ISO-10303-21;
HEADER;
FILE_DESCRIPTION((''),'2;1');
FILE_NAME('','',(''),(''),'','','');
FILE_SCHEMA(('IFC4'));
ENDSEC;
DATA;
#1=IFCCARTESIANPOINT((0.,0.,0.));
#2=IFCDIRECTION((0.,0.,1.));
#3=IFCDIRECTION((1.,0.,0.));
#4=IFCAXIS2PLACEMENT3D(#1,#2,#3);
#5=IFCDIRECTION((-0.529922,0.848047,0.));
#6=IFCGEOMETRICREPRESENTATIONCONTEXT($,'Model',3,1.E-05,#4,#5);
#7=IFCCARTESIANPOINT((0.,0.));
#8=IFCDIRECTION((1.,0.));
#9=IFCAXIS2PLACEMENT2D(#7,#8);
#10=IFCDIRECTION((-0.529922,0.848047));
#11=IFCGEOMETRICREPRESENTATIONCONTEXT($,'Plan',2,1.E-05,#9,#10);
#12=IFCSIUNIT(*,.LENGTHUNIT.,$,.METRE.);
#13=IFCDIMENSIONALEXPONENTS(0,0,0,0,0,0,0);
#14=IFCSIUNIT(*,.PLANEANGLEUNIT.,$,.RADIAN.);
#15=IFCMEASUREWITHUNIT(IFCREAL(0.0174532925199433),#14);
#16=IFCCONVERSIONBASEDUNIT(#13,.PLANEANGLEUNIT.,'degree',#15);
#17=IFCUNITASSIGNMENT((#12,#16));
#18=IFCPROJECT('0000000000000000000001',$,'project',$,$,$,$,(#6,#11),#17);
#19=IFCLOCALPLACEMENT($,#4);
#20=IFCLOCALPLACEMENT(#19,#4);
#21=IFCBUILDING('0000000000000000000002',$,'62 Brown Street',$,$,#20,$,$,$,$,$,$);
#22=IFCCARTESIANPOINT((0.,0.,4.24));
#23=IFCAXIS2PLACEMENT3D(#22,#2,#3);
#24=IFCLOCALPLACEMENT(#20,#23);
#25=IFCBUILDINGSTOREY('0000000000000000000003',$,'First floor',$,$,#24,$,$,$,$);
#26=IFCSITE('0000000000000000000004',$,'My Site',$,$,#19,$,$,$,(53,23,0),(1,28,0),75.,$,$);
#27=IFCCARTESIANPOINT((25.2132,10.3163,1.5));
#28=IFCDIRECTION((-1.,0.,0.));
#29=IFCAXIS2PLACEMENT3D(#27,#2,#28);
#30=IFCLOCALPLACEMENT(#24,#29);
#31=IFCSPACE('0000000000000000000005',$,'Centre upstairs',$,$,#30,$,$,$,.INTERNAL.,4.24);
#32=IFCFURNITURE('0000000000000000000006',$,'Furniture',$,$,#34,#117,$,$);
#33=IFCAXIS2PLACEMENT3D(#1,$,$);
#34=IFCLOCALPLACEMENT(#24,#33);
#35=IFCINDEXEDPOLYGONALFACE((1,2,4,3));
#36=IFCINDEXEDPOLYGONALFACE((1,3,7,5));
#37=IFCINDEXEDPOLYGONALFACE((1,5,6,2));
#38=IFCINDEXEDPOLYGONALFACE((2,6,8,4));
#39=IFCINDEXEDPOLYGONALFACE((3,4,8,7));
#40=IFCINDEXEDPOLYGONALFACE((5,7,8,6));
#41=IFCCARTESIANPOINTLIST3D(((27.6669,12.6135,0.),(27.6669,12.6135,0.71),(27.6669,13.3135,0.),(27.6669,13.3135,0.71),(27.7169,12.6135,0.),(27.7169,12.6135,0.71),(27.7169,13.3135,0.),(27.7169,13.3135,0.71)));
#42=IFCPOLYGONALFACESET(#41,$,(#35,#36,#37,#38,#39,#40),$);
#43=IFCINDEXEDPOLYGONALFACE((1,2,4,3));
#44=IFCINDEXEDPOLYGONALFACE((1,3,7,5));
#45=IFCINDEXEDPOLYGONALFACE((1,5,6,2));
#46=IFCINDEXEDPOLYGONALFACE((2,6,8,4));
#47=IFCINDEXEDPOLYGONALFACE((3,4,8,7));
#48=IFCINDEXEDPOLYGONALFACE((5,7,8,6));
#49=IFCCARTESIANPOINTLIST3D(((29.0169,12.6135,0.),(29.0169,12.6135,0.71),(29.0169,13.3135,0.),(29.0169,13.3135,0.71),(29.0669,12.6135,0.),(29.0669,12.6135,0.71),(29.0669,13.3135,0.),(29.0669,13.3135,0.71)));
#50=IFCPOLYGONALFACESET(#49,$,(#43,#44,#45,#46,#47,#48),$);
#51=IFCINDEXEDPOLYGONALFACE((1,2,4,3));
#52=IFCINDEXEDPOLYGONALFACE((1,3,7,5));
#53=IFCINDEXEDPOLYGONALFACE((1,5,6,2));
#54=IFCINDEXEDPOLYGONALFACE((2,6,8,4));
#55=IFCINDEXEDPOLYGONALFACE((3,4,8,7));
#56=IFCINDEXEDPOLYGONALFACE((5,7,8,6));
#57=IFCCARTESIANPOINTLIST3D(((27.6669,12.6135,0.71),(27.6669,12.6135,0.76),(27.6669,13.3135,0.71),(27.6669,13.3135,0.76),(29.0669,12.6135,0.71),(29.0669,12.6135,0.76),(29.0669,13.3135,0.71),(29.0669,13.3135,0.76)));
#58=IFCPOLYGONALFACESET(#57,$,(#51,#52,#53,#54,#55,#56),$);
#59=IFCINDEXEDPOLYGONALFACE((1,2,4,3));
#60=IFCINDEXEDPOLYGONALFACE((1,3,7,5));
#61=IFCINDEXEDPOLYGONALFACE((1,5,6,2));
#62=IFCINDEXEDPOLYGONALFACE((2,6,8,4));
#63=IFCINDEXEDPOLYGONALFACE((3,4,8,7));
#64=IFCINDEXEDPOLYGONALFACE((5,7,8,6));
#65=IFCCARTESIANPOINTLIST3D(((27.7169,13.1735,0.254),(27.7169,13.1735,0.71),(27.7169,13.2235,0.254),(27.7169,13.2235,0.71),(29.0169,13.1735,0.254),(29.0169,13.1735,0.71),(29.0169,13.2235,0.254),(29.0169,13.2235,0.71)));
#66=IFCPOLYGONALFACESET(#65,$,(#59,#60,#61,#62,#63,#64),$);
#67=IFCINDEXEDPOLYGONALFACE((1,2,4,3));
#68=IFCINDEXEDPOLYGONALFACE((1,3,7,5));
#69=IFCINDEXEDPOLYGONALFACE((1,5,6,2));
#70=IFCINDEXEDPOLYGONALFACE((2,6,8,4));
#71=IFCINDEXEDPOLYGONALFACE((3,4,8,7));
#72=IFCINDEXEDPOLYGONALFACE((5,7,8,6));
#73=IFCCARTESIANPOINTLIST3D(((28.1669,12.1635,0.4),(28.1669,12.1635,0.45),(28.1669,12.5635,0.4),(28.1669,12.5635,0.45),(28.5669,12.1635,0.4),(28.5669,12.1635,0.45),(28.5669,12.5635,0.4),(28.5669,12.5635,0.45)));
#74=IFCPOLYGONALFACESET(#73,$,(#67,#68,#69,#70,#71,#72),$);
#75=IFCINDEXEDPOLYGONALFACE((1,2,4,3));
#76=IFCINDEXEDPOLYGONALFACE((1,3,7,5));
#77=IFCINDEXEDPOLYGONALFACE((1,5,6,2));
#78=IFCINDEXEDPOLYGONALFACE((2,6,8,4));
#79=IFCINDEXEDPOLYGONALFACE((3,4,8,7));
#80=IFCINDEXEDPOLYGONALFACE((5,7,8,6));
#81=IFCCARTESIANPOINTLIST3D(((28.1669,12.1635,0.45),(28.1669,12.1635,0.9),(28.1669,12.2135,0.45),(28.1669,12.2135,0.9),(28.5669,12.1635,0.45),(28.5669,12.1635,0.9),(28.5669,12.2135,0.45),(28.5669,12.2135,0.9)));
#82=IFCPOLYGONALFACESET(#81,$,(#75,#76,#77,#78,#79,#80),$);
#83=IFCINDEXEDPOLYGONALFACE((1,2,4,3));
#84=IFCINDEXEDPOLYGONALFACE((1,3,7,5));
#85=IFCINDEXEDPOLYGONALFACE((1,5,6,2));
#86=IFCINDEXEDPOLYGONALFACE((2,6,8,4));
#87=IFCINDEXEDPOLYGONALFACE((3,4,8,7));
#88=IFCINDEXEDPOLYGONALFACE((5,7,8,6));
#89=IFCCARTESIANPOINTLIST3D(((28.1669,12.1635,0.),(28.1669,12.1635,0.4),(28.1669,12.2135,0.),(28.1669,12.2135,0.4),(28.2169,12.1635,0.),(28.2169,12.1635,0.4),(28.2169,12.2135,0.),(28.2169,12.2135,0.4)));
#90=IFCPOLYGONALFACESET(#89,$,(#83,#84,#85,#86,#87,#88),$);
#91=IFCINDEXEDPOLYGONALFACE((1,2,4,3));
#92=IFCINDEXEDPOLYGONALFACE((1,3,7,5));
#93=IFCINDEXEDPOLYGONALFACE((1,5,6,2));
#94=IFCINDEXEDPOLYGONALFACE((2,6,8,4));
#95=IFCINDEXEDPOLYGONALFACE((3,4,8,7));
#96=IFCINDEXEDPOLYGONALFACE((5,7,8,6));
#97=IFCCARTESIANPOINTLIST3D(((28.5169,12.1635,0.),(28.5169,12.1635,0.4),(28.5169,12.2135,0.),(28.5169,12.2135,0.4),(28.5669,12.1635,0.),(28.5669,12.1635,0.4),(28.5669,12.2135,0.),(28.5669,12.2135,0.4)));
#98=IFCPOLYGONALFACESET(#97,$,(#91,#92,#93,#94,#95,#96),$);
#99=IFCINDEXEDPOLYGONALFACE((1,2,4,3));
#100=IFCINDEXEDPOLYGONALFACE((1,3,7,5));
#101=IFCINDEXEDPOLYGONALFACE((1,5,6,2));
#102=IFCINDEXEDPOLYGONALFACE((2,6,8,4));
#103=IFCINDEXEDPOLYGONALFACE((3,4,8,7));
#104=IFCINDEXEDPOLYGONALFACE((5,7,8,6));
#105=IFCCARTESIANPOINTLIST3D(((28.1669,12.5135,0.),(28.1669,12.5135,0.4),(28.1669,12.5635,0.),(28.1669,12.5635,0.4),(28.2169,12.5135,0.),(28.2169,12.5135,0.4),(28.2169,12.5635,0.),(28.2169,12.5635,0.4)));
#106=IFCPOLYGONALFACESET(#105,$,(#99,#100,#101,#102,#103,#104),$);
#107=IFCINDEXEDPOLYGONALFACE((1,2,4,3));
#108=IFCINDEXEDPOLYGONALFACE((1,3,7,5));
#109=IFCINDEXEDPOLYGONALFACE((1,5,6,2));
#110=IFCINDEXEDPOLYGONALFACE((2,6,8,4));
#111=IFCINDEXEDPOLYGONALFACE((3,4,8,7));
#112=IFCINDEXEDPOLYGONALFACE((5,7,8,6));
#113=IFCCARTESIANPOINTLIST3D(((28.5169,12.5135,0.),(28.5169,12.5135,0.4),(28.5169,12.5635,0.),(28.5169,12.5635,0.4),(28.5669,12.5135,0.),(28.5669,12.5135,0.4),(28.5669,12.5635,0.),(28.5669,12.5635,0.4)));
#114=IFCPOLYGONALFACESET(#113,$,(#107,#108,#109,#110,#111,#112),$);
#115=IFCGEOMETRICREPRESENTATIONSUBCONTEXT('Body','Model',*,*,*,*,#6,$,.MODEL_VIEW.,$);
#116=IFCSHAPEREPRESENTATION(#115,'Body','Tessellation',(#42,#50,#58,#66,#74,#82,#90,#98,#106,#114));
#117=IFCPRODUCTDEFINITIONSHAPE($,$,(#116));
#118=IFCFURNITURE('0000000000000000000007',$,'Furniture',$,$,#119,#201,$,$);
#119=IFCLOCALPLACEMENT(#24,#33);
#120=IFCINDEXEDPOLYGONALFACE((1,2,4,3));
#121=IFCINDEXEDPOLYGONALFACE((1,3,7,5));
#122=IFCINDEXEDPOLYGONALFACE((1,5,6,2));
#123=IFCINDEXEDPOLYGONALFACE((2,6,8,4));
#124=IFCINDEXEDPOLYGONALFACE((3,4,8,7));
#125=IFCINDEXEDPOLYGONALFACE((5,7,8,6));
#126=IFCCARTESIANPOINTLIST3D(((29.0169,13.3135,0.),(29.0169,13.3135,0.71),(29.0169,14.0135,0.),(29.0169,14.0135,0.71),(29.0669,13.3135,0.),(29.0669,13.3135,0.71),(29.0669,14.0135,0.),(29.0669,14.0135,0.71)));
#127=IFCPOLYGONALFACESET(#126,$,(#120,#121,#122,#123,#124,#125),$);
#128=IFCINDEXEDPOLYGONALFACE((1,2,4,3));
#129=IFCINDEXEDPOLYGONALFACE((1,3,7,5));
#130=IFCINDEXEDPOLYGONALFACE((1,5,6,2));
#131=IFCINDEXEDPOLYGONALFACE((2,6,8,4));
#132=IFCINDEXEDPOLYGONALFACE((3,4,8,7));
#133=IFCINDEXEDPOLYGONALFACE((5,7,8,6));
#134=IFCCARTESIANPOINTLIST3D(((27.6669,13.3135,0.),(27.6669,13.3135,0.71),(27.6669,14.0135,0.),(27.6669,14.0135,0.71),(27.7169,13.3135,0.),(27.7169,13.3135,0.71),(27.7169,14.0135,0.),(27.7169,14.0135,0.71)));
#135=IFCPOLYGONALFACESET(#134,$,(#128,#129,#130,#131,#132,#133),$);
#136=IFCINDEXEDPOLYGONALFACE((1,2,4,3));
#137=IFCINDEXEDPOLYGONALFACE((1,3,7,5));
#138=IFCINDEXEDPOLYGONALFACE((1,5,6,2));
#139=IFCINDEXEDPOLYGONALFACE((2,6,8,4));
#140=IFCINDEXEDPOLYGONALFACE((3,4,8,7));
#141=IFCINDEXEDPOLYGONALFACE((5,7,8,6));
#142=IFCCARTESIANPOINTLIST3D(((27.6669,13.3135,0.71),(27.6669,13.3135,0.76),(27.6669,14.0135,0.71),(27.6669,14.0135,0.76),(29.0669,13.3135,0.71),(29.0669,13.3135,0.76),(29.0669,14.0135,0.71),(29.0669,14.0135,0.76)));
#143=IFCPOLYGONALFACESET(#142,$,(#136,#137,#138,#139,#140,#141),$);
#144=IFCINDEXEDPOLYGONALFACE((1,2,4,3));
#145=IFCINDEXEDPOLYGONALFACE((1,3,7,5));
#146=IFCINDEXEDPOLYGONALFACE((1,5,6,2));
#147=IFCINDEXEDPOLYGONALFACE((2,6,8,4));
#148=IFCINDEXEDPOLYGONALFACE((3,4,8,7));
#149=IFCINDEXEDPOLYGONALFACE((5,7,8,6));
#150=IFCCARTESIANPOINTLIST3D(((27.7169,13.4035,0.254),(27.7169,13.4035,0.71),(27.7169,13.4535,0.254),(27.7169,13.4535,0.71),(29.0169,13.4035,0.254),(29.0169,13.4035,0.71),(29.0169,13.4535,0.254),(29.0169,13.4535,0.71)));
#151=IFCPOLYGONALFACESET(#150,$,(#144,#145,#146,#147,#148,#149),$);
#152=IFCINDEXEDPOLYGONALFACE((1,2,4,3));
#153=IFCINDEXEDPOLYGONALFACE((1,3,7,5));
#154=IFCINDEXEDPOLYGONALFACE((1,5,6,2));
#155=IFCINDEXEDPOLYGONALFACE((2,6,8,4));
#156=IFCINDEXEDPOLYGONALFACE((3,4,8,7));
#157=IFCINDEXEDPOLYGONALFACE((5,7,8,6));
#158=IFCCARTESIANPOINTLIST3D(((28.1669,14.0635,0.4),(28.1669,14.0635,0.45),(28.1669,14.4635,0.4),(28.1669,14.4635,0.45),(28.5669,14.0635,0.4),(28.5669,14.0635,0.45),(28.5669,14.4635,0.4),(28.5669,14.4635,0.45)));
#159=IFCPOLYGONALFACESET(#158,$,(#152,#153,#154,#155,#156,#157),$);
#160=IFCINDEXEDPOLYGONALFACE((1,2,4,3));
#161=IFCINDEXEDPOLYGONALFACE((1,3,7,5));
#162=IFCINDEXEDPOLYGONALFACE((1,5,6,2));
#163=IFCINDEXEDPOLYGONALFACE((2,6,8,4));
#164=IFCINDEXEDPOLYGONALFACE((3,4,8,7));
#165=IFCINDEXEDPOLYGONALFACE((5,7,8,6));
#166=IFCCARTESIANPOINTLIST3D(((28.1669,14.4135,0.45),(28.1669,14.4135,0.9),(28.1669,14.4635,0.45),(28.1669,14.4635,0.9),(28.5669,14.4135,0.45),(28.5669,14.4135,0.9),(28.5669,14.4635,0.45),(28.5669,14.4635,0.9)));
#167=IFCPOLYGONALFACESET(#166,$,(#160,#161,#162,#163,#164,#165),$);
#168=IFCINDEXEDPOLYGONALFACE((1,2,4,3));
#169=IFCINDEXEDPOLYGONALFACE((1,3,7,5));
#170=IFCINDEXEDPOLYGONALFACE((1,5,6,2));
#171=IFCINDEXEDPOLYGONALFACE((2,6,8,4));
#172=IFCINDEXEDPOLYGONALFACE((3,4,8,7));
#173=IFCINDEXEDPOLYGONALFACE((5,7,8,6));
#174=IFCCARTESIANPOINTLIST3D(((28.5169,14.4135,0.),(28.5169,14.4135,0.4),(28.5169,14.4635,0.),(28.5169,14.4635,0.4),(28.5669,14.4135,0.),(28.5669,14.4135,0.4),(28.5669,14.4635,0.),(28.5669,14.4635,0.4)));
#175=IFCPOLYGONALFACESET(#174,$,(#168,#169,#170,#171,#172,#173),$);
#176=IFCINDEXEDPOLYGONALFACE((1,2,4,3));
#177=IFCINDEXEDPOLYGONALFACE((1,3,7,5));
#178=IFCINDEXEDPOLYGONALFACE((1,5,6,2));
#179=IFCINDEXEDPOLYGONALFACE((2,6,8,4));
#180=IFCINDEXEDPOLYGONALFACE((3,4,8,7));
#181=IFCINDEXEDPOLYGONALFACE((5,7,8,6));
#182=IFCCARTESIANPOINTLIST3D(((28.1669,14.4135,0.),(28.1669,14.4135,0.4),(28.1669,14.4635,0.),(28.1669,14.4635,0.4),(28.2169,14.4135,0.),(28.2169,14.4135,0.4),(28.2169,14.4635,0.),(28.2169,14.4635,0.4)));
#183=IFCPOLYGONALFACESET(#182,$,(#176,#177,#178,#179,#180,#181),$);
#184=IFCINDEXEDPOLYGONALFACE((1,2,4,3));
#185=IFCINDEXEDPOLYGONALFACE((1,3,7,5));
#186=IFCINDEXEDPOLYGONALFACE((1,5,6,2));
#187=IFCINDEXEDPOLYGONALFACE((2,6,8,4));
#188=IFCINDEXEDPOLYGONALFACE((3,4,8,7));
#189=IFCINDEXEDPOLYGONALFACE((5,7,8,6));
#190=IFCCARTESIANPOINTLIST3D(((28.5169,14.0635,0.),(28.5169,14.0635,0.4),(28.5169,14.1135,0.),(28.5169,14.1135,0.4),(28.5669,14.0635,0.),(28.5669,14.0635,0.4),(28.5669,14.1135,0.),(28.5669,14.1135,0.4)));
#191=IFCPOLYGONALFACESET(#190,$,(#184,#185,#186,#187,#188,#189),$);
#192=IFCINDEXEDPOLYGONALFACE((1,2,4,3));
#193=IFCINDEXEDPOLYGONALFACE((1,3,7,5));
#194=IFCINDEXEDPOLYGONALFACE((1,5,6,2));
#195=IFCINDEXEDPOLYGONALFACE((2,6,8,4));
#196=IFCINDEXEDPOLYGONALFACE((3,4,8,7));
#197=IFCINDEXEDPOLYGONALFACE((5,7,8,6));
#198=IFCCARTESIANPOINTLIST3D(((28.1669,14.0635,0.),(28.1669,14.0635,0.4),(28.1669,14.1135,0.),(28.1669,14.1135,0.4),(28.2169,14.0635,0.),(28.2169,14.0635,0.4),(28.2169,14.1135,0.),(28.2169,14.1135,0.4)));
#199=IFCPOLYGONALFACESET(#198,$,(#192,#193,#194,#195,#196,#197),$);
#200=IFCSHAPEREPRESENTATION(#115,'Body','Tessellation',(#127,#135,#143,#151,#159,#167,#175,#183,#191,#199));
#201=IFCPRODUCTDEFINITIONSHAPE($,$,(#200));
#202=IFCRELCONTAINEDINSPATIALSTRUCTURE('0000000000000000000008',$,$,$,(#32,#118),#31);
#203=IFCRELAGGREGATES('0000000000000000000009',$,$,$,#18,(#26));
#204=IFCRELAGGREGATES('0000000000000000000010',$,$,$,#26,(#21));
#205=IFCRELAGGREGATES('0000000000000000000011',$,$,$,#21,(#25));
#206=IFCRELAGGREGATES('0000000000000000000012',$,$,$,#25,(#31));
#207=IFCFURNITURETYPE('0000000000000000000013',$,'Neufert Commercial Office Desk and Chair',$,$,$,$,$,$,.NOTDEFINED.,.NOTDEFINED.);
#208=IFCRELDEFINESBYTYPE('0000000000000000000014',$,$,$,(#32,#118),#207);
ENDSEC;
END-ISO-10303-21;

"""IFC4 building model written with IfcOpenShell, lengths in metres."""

from ifc_helpers import new_model, entity, si_unit, converted_unit, direction, frame, origin_with_axes, origin_2d_with_axis, place, context, subcontext, project, spatial, line, indexed_curve, outline, extrude, shape, source, transform, mapped, type_object, type_shapes, element, save


model = new_model("IFC4")

# Units and contexts
model_context = context("Model", 3, precision=1e-05, world=origin_with_axes(), true_north=direction((-0.529922, 0.848047, 0.0)))
plan_context = context("Plan", 2, precision=1e-05, world=origin_2d_with_axis(), true_north=direction((-0.529922, 0.848047)))
body_context_1 = subcontext(model_context, "Body", "Model", "MODEL_VIEW")
body_context_2 = subcontext(plan_context, "Body", "Plan", "PLAN_VIEW")
ifc_project = project(units=[si_unit("LENGTHUNIT", "METRE"), converted_unit("PLANEANGLEUNIT", "degree", entity("IfcReal", 0.0174532925199433), si_unit("PLANEANGLEUNIT", "RADIAN"), dimensions=[0, 0, 0, 0, 0, 0, 0])], contexts=[model_context, plan_context])

# Site, building, storey, space
site_placement = place(None, origin_with_axes())
site = spatial("IfcSite", under=ifc_project, at=site_placement, Name="My Site", RefLatitude=(53, 23, 0), RefLongitude=(1, 28, 0), RefElevation=75.0)
building_placement = place(site_placement, origin_with_axes())
building = spatial("IfcBuilding", under=site, at=building_placement, Name="62 Brown Street")
storey_placement = place(building_placement, frame((0.0, 0.0, 4.24), z_axis=(0.0, 0.0, 1.0), x_axis=(1.0, 0.0, 0.0)))
storey = spatial("IfcBuildingStorey", under=building, at=storey_placement, Name="First floor")
space_placement = place(storey_placement, frame((25.2132, 10.3163, 1.5), z_axis=(0.0, 0.0, 1.0), x_axis=(-1.0, 0.0, 0.0)))
space = spatial("IfcSpace", under=storey, at=space_placement, Name="Centre upstairs", PredefinedType="INTERNAL", ElevationWithFlooring=4.24)

# Furniture
furniture_type = type_object("IfcFurnitureType", Name="Neufert Commercial Office Desk and Chair", AssemblyPlace="NOTDEFINED", PredefinedType="NOTDEFINED")
shared_shape_1 = source(origin_with_axes(), body_context_1, "Body", "SweptSolid", [
    extrude(outline(indexed_curve([(0.0, 0.0), (0.05, 0.0), (0.05, 0.7), (0.0, 0.7)], segments=[line(1, 2, 3, 4, 1)])), frame((0.0, 0.45, 0.0), z_axis=(0.0, 0.0, 1.0), x_axis=(1.0, 0.0, 0.0)), (0.0, 0.0, 1.0), 0.71),
    extrude(outline(indexed_curve([(0.0, 0.0), (0.05, 0.0), (0.05, 0.7), (0.0, 0.7)], segments=[line(1, 2, 3, 4, 1)])), frame((1.35, 0.45, 0.0), z_axis=(0.0, 0.0, 1.0), x_axis=(1.0, 0.0, 0.0)), (0.0, 0.0, 1.0), 0.71),
    extrude(outline(indexed_curve([(0.0, 0.0), (1.4, 0.0), (1.4, 0.7), (0.0, 0.7)], segments=[line(1, 2, 3, 4, 1)])), frame((0.0, 0.45, 0.71), z_axis=(0.0, 0.0, 1.0), x_axis=(1.0, 0.0, 0.0)), (0.0, 0.0, 1.0), 0.05),
    extrude(outline(indexed_curve([(0.05, 0.56), (1.35, 0.56), (1.35, 0.61), (0.05, 0.61)], segments=[line(1, 2, 3, 4, 1)])), frame((0.0, 0.45, 0.254), z_axis=(0.0, 0.0, 1.0), x_axis=(1.0, 0.0, 0.0)), (0.0, 0.0, 1.0), 0.456),
    extrude(outline(indexed_curve([(-0.2, 0.0), (0.2, 0.0), (0.2, 0.4), (-0.2, 0.4)], segments=[line(1, 2, 3, 4, 1)])), frame((0.7, 0.0, 0.45), z_axis=(0.0, 0.0, 1.0), x_axis=(1.0, 0.0, 0.0)), (0.0, 0.0, -1.0), 0.05),
    extrude(outline(indexed_curve([(-0.2, 0.0), (0.2, 0.0), (0.2, 0.05), (-0.2, 0.05)], segments=[line(1, 2, 3, 4, 1)])), frame((0.7, 0.0, 0.9), z_axis=(0.0, 0.0, 1.0), x_axis=(1.0, 0.0, 0.0)), (0.0, 0.0, -1.0), 0.45),
    extrude(outline(indexed_curve([(-0.2, 0.0), (-0.15, 0.0), (-0.15, 0.05), (-0.2, 0.05)], segments=[line(1, 2, 3, 4, 1)])), frame((0.7, 0.0, 0.0), z_axis=(0.0, 0.0, 1.0), x_axis=(1.0, 0.0, 0.0)), (0.0, 0.0, 1.0), 0.4),
    extrude(outline(indexed_curve([(0.2, 0.0), (0.15, 0.0), (0.15, 0.05), (0.2, 0.05)], segments=[line(1, 2, 3, 4, 1)])), frame((0.7, 0.0, 0.0), z_axis=(0.0, 0.0, 1.0), x_axis=(1.0, 0.0, 0.0)), (0.0, 0.0, 1.0), 0.4),
    extrude(outline(indexed_curve([(-0.2, 0.4), (-0.15, 0.4), (-0.15, 0.35), (-0.2, 0.35)], segments=[line(1, 2, 3, 4, 1)])), frame((0.7, 0.0, 0.0), z_axis=(0.0, 0.0, 1.0), x_axis=(1.0, 0.0, 0.0)), (0.0, 0.0, 1.0), 0.4),
    extrude(outline(indexed_curve([(0.2, 0.4), (0.15, 0.4), (0.15, 0.35), (0.2, 0.35)], segments=[line(1, 2, 3, 4, 1)])), frame((0.7, 0.0, 0.0), z_axis=(0.0, 0.0, 1.0), x_axis=(1.0, 0.0, 0.0)), (0.0, 0.0, 1.0), 0.4),
])
shared_shape_2 = source(origin_with_axes(), body_context_2, "Body", "Curve2D", [
    entity("IfcIndexedPolyCurve", entity("IfcCartesianPointList2D", [[0.0, 0.45], [1.4, 0.45], [1.4, 1.15], [0.0, 1.15]]), [entity("IfcLineIndex", [1, 2, 3, 4, 1])]),
    entity("IfcIndexedPolyCurve", entity("IfcCartesianPointList2D", [[0.5, 0.4], [0.9, 0.4]])),
    entity("IfcIndexedPolyCurve", entity("IfcCartesianPointList2D", [[0.5, 0.4], [0.5, 0.2], [0.5586, 0.0586], [0.7, 0.0], [0.8414, 0.0586], [0.9, 0.2], [0.9, 0.4]]), [entity("IfcLineIndex", [1, 2]), entity("IfcArcIndex", [2, 3, 4]), entity("IfcArcIndex", [4, 5, 6]), entity("IfcLineIndex", [6, 7])]),
    entity("IfcIndexedPolyCurve", entity("IfcCartesianPointList2D", [[0.54, 0.4], [0.54, 0.2], [0.5869, 0.0869], [0.7, 0.04], [0.8131, 0.0869], [0.86, 0.2], [0.86, 0.4]]), [entity("IfcLineIndex", [1, 2]), entity("IfcArcIndex", [2, 3, 4]), entity("IfcArcIndex", [4, 5, 6]), entity("IfcLineIndex", [6, 7])]),
])
type_shapes(furniture_type, [shared_shape_1, shared_shape_2])
for number, where, z_axis, x_axis, name in (
    (1, (-2.4537, -1.8472, -1.5), (0.0, 0.0, 1.0), (-1.0, 0.0, 0.0), "Furniture"),
    (2, (-3.8537, -4.1472, -1.5), (0.0, 0.0, 1.0), (1.0, 0.0, 0.0), "Furniture"),
):
    element("IfcFurniture", number, at=place(space_placement, frame(where, z_axis=z_axis, x_axis=x_axis)), inside=space, type_object=furniture_type, Name=name, shapes=[
        shape(body_context_1, "Body", "MappedRepresentation", [mapped(shared_shape_1, transform((0.0, 0.0, 0.0), x_axis=(1.0, 0.0, 0.0), y_axis=(0.0, 1.0, 0.0), z_axis=(0.0, 0.0, 1.0), scale=1.0))]),
        shape(body_context_2, "Body", "MappedRepresentation", [mapped(shared_shape_2, transform((0.0, 0.0, 0.0), x_axis=(1.0, 0.0, 0.0), y_axis=(0.0, 1.0, 0.0), z_axis=(0.0, 0.0, 1.0), scale=1.0))]),
    ])

save(model, "model.ifc")
